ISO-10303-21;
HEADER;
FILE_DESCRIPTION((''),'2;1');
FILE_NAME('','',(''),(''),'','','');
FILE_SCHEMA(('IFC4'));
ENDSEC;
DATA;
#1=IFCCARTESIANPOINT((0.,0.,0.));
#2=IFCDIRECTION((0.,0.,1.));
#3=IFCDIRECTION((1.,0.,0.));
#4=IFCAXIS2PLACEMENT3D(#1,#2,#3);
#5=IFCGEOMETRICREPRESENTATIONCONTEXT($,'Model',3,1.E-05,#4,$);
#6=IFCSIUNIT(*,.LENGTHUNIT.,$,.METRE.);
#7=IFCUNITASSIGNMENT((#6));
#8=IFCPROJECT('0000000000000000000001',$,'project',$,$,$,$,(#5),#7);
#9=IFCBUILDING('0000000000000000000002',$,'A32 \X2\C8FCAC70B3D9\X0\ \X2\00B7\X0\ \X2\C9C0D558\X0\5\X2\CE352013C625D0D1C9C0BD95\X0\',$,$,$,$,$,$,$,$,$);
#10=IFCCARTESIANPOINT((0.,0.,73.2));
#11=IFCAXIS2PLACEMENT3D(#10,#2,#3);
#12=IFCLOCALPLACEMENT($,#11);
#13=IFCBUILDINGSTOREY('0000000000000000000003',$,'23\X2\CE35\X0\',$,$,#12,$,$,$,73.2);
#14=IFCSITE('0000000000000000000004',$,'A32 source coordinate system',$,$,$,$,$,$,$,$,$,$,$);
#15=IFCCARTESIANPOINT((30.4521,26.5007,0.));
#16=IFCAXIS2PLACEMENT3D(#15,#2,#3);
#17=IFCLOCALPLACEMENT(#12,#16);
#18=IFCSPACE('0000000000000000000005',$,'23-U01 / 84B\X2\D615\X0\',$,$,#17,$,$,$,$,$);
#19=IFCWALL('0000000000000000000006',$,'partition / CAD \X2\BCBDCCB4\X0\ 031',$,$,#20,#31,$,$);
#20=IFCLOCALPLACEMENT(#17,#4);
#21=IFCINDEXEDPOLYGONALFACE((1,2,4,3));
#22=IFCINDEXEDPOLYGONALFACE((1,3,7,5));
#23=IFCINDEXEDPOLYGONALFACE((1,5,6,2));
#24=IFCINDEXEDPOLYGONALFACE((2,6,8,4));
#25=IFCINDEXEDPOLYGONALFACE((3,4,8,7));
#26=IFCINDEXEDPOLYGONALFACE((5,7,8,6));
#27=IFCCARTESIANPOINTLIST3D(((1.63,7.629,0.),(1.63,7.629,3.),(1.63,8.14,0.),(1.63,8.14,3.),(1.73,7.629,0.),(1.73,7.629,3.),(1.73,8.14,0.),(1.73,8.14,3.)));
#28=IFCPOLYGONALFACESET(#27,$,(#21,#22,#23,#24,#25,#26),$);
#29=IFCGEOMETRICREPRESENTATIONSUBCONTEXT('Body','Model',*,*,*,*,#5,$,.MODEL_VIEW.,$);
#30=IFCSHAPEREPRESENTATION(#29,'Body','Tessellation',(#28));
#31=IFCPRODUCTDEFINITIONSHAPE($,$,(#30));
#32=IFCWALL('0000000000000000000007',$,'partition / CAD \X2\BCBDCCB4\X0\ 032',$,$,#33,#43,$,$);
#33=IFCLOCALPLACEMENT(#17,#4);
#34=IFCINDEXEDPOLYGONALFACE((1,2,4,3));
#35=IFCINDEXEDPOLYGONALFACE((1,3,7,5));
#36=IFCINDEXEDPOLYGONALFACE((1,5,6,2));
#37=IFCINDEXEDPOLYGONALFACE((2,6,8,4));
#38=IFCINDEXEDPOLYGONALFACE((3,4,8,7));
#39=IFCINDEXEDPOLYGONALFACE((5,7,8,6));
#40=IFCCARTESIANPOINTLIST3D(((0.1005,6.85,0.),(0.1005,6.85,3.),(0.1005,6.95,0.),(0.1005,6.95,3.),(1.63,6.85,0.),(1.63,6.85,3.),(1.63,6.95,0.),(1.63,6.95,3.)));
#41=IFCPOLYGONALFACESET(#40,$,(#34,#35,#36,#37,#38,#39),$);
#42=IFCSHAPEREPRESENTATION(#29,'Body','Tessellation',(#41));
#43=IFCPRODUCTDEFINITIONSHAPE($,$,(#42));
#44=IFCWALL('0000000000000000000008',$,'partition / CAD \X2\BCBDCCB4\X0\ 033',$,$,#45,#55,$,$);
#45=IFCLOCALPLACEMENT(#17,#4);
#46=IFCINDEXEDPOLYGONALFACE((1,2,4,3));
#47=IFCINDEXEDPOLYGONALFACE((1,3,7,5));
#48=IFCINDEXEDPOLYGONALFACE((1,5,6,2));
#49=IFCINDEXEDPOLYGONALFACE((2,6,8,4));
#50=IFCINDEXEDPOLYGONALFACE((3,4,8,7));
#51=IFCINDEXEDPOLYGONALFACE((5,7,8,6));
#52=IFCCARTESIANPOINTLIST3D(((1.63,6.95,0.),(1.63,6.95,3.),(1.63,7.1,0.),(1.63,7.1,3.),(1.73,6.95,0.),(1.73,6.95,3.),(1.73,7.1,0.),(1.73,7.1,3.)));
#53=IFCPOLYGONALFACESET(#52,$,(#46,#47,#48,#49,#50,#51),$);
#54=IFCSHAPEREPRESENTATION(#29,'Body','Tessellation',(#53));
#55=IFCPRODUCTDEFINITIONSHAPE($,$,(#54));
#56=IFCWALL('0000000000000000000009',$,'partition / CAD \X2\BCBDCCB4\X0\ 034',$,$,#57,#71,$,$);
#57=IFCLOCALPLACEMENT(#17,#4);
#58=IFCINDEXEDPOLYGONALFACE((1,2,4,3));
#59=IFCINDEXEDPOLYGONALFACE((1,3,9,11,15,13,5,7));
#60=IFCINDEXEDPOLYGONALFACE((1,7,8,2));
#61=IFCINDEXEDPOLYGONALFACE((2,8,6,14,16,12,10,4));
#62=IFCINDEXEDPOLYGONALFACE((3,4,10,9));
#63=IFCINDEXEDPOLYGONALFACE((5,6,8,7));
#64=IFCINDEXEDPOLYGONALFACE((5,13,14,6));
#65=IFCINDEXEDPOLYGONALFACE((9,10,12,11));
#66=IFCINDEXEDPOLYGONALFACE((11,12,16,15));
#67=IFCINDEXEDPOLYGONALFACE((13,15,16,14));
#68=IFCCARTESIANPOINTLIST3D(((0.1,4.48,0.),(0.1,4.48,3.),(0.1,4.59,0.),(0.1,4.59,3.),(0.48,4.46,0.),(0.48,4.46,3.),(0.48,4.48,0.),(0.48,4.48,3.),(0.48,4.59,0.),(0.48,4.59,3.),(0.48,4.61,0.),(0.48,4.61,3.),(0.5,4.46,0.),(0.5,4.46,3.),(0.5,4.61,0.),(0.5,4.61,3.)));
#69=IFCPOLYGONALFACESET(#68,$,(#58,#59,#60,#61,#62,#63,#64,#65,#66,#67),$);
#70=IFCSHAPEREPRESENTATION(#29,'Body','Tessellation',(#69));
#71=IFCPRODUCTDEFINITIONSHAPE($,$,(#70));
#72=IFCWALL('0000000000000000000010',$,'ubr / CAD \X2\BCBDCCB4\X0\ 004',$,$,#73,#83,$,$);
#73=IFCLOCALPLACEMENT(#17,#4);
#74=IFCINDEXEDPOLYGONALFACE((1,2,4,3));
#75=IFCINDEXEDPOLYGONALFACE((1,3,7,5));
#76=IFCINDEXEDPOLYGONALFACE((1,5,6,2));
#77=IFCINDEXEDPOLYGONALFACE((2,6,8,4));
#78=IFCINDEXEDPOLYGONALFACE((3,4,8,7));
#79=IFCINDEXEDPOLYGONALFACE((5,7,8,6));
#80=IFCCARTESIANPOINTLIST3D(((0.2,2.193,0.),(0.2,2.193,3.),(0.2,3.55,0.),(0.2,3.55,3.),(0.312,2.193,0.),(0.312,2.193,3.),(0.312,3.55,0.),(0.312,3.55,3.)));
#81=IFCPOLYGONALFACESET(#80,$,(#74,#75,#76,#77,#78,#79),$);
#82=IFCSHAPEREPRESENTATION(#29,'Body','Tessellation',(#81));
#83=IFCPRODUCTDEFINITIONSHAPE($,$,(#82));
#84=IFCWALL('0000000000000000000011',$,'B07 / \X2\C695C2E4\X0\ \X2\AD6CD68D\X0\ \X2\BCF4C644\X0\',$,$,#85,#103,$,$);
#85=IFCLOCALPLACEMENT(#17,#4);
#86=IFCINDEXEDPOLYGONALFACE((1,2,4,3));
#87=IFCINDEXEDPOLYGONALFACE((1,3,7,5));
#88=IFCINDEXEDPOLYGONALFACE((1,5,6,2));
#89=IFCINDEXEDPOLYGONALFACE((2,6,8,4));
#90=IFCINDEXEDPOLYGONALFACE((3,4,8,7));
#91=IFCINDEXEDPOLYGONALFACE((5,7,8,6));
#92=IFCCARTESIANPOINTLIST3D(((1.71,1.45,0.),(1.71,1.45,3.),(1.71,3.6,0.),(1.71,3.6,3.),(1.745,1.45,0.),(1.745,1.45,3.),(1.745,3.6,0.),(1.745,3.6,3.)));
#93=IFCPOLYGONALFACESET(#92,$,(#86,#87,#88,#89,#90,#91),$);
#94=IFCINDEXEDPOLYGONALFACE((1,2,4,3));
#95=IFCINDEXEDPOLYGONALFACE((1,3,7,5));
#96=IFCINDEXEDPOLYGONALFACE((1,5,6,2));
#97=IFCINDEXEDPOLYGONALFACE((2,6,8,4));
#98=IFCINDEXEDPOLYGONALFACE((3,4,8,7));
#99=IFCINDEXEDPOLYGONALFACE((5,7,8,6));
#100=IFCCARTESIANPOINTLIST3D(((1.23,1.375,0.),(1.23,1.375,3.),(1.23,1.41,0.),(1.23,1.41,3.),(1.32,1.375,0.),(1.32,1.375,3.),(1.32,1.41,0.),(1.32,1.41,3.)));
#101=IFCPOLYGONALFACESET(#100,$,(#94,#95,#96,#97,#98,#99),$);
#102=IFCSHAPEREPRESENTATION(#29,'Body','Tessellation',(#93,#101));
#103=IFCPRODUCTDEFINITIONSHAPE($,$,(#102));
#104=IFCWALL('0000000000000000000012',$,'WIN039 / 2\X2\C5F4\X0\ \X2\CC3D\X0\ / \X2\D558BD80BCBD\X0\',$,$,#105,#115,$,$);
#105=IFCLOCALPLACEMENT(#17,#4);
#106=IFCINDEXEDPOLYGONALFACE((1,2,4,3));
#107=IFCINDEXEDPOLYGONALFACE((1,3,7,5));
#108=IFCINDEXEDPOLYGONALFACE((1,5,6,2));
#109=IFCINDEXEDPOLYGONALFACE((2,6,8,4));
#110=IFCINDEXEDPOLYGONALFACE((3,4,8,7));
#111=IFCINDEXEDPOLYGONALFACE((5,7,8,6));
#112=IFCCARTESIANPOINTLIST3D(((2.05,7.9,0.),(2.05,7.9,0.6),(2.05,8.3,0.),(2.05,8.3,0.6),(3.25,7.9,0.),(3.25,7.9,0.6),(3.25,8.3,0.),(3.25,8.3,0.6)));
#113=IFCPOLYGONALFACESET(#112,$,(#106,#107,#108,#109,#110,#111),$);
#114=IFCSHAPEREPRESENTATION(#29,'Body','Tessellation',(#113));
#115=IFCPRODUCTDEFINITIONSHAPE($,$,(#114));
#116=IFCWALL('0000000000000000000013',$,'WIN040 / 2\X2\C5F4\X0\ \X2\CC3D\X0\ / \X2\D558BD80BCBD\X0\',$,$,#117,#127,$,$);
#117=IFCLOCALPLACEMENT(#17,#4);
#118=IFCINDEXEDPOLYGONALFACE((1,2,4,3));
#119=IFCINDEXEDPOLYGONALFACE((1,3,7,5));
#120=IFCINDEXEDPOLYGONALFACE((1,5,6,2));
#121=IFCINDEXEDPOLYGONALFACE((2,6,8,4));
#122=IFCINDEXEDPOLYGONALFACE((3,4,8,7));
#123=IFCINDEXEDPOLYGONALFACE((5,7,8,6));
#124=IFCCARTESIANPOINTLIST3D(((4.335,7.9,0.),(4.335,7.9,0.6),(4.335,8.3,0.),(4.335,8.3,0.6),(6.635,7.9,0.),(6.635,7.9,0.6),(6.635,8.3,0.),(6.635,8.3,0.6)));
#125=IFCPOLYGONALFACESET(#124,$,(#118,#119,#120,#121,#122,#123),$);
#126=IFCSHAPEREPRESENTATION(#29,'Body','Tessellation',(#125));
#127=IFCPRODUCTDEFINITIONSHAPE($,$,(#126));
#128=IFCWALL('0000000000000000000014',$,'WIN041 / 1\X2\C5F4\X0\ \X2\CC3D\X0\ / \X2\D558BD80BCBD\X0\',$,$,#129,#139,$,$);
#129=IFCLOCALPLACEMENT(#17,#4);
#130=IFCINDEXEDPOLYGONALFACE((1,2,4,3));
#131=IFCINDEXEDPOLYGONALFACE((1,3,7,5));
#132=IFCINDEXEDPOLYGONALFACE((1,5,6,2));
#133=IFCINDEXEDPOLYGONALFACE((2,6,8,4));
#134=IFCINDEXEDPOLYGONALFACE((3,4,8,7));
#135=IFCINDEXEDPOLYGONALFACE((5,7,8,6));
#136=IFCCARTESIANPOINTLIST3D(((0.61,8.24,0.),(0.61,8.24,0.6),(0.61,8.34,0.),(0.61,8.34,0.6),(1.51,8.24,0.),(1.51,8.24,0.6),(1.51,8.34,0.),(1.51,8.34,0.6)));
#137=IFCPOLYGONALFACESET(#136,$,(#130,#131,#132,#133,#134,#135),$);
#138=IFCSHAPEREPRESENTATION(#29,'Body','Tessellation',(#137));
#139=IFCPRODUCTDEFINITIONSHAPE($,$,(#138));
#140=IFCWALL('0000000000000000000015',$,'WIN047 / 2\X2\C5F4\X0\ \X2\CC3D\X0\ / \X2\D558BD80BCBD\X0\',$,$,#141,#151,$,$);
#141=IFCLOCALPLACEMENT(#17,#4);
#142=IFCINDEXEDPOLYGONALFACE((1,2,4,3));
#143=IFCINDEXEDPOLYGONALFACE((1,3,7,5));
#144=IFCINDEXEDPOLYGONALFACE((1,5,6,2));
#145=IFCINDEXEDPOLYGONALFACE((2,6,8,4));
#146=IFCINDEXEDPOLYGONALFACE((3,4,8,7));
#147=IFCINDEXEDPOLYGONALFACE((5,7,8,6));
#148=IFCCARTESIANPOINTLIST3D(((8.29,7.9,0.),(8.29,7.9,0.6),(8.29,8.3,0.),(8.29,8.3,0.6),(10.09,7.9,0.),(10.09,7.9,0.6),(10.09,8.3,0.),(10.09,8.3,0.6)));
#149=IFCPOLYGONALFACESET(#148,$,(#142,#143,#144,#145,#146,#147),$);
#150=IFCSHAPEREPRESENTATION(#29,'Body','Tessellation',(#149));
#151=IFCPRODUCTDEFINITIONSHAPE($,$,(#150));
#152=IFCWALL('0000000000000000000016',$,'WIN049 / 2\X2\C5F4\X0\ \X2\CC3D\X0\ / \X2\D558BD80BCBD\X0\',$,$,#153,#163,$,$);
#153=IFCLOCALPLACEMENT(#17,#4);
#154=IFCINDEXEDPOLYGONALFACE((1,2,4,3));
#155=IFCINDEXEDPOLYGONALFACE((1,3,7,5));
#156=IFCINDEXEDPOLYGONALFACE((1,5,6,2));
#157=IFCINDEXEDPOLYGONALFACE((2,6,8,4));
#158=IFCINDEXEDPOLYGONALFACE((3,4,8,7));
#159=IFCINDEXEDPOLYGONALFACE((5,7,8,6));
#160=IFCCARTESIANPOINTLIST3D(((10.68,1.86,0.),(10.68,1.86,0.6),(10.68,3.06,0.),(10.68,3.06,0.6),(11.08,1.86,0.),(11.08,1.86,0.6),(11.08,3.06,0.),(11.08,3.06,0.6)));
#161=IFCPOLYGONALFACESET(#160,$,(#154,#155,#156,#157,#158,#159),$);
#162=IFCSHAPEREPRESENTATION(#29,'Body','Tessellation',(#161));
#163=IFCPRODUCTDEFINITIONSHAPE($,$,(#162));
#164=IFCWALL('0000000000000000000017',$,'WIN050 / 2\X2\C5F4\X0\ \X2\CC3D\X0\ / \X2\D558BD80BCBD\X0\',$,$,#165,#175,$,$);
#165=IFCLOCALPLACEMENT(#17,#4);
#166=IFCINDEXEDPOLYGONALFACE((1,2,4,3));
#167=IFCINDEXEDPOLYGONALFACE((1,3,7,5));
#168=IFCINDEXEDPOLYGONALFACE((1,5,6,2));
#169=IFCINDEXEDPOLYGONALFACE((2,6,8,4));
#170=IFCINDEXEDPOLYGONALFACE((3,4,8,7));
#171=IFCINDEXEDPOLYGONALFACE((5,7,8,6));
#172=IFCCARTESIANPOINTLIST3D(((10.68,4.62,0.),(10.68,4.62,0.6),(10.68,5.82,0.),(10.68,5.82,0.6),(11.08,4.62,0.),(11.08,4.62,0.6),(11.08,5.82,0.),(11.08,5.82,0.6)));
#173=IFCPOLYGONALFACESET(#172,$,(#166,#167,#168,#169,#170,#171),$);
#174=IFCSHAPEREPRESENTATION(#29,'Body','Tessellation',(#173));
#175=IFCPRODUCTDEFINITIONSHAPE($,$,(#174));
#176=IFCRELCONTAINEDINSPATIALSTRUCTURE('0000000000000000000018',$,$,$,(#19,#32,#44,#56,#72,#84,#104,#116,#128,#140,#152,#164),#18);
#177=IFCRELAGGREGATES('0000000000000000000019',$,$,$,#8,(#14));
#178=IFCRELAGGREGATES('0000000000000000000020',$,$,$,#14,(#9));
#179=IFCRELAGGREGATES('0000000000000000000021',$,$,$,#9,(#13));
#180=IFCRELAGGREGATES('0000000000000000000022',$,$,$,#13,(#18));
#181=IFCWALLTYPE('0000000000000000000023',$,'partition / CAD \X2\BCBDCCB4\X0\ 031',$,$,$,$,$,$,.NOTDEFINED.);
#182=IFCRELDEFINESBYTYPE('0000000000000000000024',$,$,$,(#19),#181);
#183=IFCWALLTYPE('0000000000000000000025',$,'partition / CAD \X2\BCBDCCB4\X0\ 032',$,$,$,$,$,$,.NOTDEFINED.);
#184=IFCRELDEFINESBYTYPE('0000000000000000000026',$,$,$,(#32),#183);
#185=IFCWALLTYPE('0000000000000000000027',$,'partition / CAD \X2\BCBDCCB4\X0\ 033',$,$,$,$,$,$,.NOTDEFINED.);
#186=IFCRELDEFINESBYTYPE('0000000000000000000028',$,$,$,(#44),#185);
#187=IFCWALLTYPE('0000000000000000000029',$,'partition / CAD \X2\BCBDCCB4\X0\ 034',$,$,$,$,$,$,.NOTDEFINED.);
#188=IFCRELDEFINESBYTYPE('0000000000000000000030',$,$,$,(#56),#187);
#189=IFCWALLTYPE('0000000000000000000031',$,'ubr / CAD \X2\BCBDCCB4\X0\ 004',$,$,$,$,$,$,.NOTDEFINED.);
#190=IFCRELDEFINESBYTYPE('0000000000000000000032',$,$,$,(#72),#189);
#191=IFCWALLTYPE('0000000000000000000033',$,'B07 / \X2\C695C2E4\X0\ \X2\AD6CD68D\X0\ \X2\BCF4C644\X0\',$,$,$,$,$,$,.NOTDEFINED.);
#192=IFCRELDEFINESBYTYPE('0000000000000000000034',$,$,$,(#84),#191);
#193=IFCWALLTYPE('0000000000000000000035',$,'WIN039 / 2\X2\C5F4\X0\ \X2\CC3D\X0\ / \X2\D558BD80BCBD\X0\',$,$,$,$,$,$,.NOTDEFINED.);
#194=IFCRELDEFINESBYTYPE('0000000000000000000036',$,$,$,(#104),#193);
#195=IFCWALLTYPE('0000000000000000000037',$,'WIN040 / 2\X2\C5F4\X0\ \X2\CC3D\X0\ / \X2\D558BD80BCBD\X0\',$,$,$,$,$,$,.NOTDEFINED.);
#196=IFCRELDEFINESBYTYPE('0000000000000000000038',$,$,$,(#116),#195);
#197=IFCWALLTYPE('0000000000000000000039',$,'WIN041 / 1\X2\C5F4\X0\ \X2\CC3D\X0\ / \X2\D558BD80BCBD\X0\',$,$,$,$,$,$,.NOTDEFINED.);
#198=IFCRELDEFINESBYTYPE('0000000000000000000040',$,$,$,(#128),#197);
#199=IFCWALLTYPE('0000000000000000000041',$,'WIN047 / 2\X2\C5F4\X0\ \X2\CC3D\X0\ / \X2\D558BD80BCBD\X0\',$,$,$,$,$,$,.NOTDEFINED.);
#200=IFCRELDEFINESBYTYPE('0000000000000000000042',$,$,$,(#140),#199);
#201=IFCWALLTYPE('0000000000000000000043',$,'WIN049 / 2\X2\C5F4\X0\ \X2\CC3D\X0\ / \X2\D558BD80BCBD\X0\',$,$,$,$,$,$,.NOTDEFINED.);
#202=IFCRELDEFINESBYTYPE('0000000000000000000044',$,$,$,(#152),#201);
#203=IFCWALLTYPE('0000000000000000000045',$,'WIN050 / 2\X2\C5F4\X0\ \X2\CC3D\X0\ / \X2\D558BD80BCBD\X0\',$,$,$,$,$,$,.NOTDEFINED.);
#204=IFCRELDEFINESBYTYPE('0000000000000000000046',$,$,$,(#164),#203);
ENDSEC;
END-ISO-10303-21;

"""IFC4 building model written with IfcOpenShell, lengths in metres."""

from ifc_helpers import new_model, si_unit, frame, origin, origin_with_axes, place, context, subcontext, project, spatial, polyline, outline, extrude, source, transform, mapped, type_object, type_shapes, element, save


model = new_model("IFC4")

# Units and contexts
model_context = context("Model", 3, precision=1e-05, world=origin_with_axes())
body_context = subcontext(model_context, "Body", "Model", "MODEL_VIEW")
ifc_project = project(units=[si_unit("LENGTHUNIT", "METRE")], contexts=[model_context])

# Site, building, storey, space
site = spatial("IfcSite", under=ifc_project, Name="A32 source coordinate system")
building = spatial("IfcBuilding", under=site, Name="A32 주거동 · 지하5층–옥탑지붕")
storey_placement = place(None, frame((0.0, 0.0, 73.2), z_axis=(0.0, 0.0, 1.0), x_axis=(1.0, 0.0, 0.0)))
storey = spatial("IfcBuildingStorey", under=building, at=storey_placement, Name="23층", Elevation=73.2)
space_placement = place(storey_placement, frame((30.4521, 26.5007, 0.0), z_axis=(0.0, 0.0, 1.0), x_axis=(1.0, 0.0, 0.0)))
space = spatial("IfcSpace", under=storey, at=space_placement, Name="23-U01 / 84B형")

# Walls
wall_type_1 = type_object("IfcWallType", Name="partition / CAD 벽체 031", PredefinedType="NOTDEFINED")
shared_shape_1 = source(origin(), body_context, "Body", "SweptSolid", [
    extrude(outline(polyline([(1.63, 8.14), (1.73, 8.14), (1.73, 7.629), (1.63, 7.629), (1.63, 8.14)])), origin(), (0.0, 0.0, 1.0), 3.0),
])
type_shapes(wall_type_1, [shared_shape_1])
wall_1_placement = place(space_placement, origin_with_axes())
element("IfcWall", 1, at=wall_1_placement, inside=space, type_object=wall_type_1, Name="partition / CAD 벽체 031", context=body_context, shape_type="MappedRepresentation", body=[
    mapped(shared_shape_1, transform((0.0, 0.0, 0.0), scale=1.0)),
])
wall_type_2 = type_object("IfcWallType", Name="partition / CAD 벽체 032", PredefinedType="NOTDEFINED")
shared_shape_2 = source(origin(), body_context, "Body", "SweptSolid", [
    extrude(outline(polyline([(0.1005, 6.95), (1.63, 6.95), (1.63, 6.85), (0.1005, 6.85), (0.1005, 6.95)])), origin(), (0.0, 0.0, 1.0), 3.0),
])
type_shapes(wall_type_2, [shared_shape_2])
wall_2_placement = place(space_placement, origin_with_axes())
element("IfcWall", 2, at=wall_2_placement, inside=space, type_object=wall_type_2, Name="partition / CAD 벽체 032", context=body_context, shape_type="MappedRepresentation", body=[
    mapped(shared_shape_2, transform((0.0, 0.0, 0.0), scale=1.0)),
])
wall_type_3 = type_object("IfcWallType", Name="partition / CAD 벽체 033", PredefinedType="NOTDEFINED")
shared_shape_3 = source(origin(), body_context, "Body", "SweptSolid", [
    extrude(outline(polyline([(1.63, 7.1), (1.73, 7.1), (1.73, 6.95), (1.63, 6.95), (1.63, 7.1)])), origin(), (0.0, 0.0, 1.0), 3.0),
])
type_shapes(wall_type_3, [shared_shape_3])
wall_3_placement = place(space_placement, origin_with_axes())
element("IfcWall", 3, at=wall_3_placement, inside=space, type_object=wall_type_3, Name="partition / CAD 벽체 033", context=body_context, shape_type="MappedRepresentation", body=[
    mapped(shared_shape_3, transform((0.0, 0.0, 0.0), scale=1.0)),
])
wall_type_4 = type_object("IfcWallType", Name="partition / CAD 벽체 034", PredefinedType="NOTDEFINED")
shared_shape_4 = source(origin(), body_context, "Body", "SweptSolid", [
    extrude(outline(polyline([(0.48, 4.61), (0.5, 4.61), (0.5, 4.46), (0.48, 4.46), (0.48, 4.48), (0.1, 4.48), (0.1, 4.59), (0.48, 4.59), (0.48, 4.61)])), origin(), (0.0, 0.0, 1.0), 3.0),
])
type_shapes(wall_type_4, [shared_shape_4])
wall_4_placement = place(space_placement, origin_with_axes())
element("IfcWall", 4, at=wall_4_placement, inside=space, type_object=wall_type_4, Name="partition / CAD 벽체 034", context=body_context, shape_type="MappedRepresentation", body=[
    mapped(shared_shape_4, transform((0.0, 0.0, 0.0), scale=1.0)),
])
wall_type_5 = type_object("IfcWallType", Name="ubr / CAD 벽체 004", PredefinedType="NOTDEFINED")
shared_shape_5 = source(origin(), body_context, "Body", "SweptSolid", [
    extrude(outline(polyline([(0.312, 2.193), (0.2, 2.193), (0.2, 3.55), (0.312, 3.55), (0.312, 2.193)])), origin(), (0.0, 0.0, 1.0), 3.0),
])
type_shapes(wall_type_5, [shared_shape_5])
wall_5_placement = place(space_placement, origin_with_axes())
element("IfcWall", 5, at=wall_5_placement, inside=space, type_object=wall_type_5, Name="ubr / CAD 벽체 004", context=body_context, shape_type="MappedRepresentation", body=[
    mapped(shared_shape_5, transform((0.0, 0.0, 0.0), scale=1.0)),
])
wall_type_6 = type_object("IfcWallType", Name="B07 / 욕실 구획 보완", PredefinedType="NOTDEFINED")
shared_shape_6 = source(origin(), body_context, "Body", "SweptSolid", [
    extrude(outline(polyline([(1.71, 1.45), (1.71, 3.6), (1.745, 3.6), (1.745, 1.45), (1.71, 1.45)])), origin(), (0.0, 0.0, 1.0), 3.0),
    extrude(outline(polyline([(1.32, 1.41), (1.32, 1.375), (1.23, 1.375), (1.23, 1.41), (1.32, 1.41)])), origin(), (0.0, 0.0, 1.0), 3.0),
])
type_shapes(wall_type_6, [shared_shape_6])
wall_6_placement = place(space_placement, origin_with_axes())
element("IfcWall", 6, at=wall_6_placement, inside=space, type_object=wall_type_6, Name="B07 / 욕실 구획 보완", context=body_context, shape_type="MappedRepresentation", body=[
    mapped(shared_shape_6, transform((0.0, 0.0, 0.0), scale=1.0)),
])
wall_type_7 = type_object("IfcWallType", Name="WIN039 / 2열 창 / 하부벽", PredefinedType="NOTDEFINED")
shared_shape_7 = source(origin(), body_context, "Body", "SweptSolid", [
    extrude(outline(polyline([(2.05, 8.3), (3.25, 8.3), (3.25, 7.9), (2.05, 7.9), (2.05, 8.3)])), origin(), (0.0, 0.0, 1.0), 0.6),
])
type_shapes(wall_type_7, [shared_shape_7])
wall_7_placement = place(space_placement, origin_with_axes())
element("IfcWall", 7, at=wall_7_placement, inside=space, type_object=wall_type_7, Name="WIN039 / 2열 창 / 하부벽", context=body_context, shape_type="MappedRepresentation", body=[
    mapped(shared_shape_7, transform((0.0, 0.0, 0.0), scale=1.0)),
])
wall_type_8 = type_object("IfcWallType", Name="WIN040 / 2열 창 / 하부벽", PredefinedType="NOTDEFINED")
shared_shape_8 = source(origin(), body_context, "Body", "SweptSolid", [
    extrude(outline(polyline([(4.335, 8.3), (6.635, 8.3), (6.635, 7.9), (4.335, 7.9), (4.335, 8.3)])), origin(), (0.0, 0.0, 1.0), 0.6),
])
type_shapes(wall_type_8, [shared_shape_8])
wall_8_placement = place(space_placement, origin_with_axes())
element("IfcWall", 8, at=wall_8_placement, inside=space, type_object=wall_type_8, Name="WIN040 / 2열 창 / 하부벽", context=body_context, shape_type="MappedRepresentation", body=[
    mapped(shared_shape_8, transform((0.0, 0.0, 0.0), scale=1.0)),
])
wall_type_9 = type_object("IfcWallType", Name="WIN041 / 1열 창 / 하부벽", PredefinedType="NOTDEFINED")
shared_shape_9 = source(origin(), body_context, "Body", "SweptSolid", [
    extrude(outline(polyline([(0.61, 8.34), (1.51, 8.34), (1.51, 8.24), (0.61, 8.24), (0.61, 8.34)])), origin(), (0.0, 0.0, 1.0), 0.6),
])
type_shapes(wall_type_9, [shared_shape_9])
wall_9_placement = place(space_placement, origin_with_axes())
element("IfcWall", 9, at=wall_9_placement, inside=space, type_object=wall_type_9, Name="WIN041 / 1열 창 / 하부벽", context=body_context, shape_type="MappedRepresentation", body=[
    mapped(shared_shape_9, transform((0.0, 0.0, 0.0), scale=1.0)),
])
wall_type_10 = type_object("IfcWallType", Name="WIN047 / 2열 창 / 하부벽", PredefinedType="NOTDEFINED")
shared_shape_10 = source(origin(), body_context, "Body", "SweptSolid", [
    extrude(outline(polyline([(8.29, 8.3), (10.09, 8.3), (10.09, 7.9), (8.29, 7.9), (8.29, 8.3)])), origin(), (0.0, 0.0, 1.0), 0.6),
])
type_shapes(wall_type_10, [shared_shape_10])
wall_10_placement = place(space_placement, origin_with_axes())
element("IfcWall", 10, at=wall_10_placement, inside=space, type_object=wall_type_10, Name="WIN047 / 2열 창 / 하부벽", context=body_context, shape_type="MappedRepresentation", body=[
    mapped(shared_shape_10, transform((0.0, 0.0, 0.0), scale=1.0)),
])
wall_type_11 = type_object("IfcWallType", Name="WIN049 / 2열 창 / 하부벽", PredefinedType="NOTDEFINED")
shared_shape_11 = source(origin(), body_context, "Body", "SweptSolid", [
    extrude(outline(polyline([(10.68, 3.06), (11.08, 3.06), (11.08, 1.86), (10.68, 1.86), (10.68, 3.06)])), origin(), (0.0, 0.0, 1.0), 0.6),
])
type_shapes(wall_type_11, [shared_shape_11])
wall_11_placement = place(space_placement, origin_with_axes())
element("IfcWall", 11, at=wall_11_placement, inside=space, type_object=wall_type_11, Name="WIN049 / 2열 창 / 하부벽", context=body_context, shape_type="MappedRepresentation", body=[
    mapped(shared_shape_11, transform((0.0, 0.0, 0.0), scale=1.0)),
])
wall_type_12 = type_object("IfcWallType", Name="WIN050 / 2열 창 / 하부벽", PredefinedType="NOTDEFINED")
shared_shape_12 = source(origin(), body_context, "Body", "SweptSolid", [
    extrude(outline(polyline([(10.68, 5.82), (11.08, 5.82), (11.08, 4.62), (10.68, 4.62), (10.68, 5.82)])), origin(), (0.0, 0.0, 1.0), 0.6),
])
type_shapes(wall_type_12, [shared_shape_12])
wall_12_placement = place(space_placement, origin_with_axes())
element("IfcWall", 12, at=wall_12_placement, inside=space, type_object=wall_type_12, Name="WIN050 / 2열 창 / 하부벽", context=body_context, shape_type="MappedRepresentation", body=[
    mapped(shared_shape_12, transform((0.0, 0.0, 0.0), scale=1.0)),
])

save(model, "model.ifc")
